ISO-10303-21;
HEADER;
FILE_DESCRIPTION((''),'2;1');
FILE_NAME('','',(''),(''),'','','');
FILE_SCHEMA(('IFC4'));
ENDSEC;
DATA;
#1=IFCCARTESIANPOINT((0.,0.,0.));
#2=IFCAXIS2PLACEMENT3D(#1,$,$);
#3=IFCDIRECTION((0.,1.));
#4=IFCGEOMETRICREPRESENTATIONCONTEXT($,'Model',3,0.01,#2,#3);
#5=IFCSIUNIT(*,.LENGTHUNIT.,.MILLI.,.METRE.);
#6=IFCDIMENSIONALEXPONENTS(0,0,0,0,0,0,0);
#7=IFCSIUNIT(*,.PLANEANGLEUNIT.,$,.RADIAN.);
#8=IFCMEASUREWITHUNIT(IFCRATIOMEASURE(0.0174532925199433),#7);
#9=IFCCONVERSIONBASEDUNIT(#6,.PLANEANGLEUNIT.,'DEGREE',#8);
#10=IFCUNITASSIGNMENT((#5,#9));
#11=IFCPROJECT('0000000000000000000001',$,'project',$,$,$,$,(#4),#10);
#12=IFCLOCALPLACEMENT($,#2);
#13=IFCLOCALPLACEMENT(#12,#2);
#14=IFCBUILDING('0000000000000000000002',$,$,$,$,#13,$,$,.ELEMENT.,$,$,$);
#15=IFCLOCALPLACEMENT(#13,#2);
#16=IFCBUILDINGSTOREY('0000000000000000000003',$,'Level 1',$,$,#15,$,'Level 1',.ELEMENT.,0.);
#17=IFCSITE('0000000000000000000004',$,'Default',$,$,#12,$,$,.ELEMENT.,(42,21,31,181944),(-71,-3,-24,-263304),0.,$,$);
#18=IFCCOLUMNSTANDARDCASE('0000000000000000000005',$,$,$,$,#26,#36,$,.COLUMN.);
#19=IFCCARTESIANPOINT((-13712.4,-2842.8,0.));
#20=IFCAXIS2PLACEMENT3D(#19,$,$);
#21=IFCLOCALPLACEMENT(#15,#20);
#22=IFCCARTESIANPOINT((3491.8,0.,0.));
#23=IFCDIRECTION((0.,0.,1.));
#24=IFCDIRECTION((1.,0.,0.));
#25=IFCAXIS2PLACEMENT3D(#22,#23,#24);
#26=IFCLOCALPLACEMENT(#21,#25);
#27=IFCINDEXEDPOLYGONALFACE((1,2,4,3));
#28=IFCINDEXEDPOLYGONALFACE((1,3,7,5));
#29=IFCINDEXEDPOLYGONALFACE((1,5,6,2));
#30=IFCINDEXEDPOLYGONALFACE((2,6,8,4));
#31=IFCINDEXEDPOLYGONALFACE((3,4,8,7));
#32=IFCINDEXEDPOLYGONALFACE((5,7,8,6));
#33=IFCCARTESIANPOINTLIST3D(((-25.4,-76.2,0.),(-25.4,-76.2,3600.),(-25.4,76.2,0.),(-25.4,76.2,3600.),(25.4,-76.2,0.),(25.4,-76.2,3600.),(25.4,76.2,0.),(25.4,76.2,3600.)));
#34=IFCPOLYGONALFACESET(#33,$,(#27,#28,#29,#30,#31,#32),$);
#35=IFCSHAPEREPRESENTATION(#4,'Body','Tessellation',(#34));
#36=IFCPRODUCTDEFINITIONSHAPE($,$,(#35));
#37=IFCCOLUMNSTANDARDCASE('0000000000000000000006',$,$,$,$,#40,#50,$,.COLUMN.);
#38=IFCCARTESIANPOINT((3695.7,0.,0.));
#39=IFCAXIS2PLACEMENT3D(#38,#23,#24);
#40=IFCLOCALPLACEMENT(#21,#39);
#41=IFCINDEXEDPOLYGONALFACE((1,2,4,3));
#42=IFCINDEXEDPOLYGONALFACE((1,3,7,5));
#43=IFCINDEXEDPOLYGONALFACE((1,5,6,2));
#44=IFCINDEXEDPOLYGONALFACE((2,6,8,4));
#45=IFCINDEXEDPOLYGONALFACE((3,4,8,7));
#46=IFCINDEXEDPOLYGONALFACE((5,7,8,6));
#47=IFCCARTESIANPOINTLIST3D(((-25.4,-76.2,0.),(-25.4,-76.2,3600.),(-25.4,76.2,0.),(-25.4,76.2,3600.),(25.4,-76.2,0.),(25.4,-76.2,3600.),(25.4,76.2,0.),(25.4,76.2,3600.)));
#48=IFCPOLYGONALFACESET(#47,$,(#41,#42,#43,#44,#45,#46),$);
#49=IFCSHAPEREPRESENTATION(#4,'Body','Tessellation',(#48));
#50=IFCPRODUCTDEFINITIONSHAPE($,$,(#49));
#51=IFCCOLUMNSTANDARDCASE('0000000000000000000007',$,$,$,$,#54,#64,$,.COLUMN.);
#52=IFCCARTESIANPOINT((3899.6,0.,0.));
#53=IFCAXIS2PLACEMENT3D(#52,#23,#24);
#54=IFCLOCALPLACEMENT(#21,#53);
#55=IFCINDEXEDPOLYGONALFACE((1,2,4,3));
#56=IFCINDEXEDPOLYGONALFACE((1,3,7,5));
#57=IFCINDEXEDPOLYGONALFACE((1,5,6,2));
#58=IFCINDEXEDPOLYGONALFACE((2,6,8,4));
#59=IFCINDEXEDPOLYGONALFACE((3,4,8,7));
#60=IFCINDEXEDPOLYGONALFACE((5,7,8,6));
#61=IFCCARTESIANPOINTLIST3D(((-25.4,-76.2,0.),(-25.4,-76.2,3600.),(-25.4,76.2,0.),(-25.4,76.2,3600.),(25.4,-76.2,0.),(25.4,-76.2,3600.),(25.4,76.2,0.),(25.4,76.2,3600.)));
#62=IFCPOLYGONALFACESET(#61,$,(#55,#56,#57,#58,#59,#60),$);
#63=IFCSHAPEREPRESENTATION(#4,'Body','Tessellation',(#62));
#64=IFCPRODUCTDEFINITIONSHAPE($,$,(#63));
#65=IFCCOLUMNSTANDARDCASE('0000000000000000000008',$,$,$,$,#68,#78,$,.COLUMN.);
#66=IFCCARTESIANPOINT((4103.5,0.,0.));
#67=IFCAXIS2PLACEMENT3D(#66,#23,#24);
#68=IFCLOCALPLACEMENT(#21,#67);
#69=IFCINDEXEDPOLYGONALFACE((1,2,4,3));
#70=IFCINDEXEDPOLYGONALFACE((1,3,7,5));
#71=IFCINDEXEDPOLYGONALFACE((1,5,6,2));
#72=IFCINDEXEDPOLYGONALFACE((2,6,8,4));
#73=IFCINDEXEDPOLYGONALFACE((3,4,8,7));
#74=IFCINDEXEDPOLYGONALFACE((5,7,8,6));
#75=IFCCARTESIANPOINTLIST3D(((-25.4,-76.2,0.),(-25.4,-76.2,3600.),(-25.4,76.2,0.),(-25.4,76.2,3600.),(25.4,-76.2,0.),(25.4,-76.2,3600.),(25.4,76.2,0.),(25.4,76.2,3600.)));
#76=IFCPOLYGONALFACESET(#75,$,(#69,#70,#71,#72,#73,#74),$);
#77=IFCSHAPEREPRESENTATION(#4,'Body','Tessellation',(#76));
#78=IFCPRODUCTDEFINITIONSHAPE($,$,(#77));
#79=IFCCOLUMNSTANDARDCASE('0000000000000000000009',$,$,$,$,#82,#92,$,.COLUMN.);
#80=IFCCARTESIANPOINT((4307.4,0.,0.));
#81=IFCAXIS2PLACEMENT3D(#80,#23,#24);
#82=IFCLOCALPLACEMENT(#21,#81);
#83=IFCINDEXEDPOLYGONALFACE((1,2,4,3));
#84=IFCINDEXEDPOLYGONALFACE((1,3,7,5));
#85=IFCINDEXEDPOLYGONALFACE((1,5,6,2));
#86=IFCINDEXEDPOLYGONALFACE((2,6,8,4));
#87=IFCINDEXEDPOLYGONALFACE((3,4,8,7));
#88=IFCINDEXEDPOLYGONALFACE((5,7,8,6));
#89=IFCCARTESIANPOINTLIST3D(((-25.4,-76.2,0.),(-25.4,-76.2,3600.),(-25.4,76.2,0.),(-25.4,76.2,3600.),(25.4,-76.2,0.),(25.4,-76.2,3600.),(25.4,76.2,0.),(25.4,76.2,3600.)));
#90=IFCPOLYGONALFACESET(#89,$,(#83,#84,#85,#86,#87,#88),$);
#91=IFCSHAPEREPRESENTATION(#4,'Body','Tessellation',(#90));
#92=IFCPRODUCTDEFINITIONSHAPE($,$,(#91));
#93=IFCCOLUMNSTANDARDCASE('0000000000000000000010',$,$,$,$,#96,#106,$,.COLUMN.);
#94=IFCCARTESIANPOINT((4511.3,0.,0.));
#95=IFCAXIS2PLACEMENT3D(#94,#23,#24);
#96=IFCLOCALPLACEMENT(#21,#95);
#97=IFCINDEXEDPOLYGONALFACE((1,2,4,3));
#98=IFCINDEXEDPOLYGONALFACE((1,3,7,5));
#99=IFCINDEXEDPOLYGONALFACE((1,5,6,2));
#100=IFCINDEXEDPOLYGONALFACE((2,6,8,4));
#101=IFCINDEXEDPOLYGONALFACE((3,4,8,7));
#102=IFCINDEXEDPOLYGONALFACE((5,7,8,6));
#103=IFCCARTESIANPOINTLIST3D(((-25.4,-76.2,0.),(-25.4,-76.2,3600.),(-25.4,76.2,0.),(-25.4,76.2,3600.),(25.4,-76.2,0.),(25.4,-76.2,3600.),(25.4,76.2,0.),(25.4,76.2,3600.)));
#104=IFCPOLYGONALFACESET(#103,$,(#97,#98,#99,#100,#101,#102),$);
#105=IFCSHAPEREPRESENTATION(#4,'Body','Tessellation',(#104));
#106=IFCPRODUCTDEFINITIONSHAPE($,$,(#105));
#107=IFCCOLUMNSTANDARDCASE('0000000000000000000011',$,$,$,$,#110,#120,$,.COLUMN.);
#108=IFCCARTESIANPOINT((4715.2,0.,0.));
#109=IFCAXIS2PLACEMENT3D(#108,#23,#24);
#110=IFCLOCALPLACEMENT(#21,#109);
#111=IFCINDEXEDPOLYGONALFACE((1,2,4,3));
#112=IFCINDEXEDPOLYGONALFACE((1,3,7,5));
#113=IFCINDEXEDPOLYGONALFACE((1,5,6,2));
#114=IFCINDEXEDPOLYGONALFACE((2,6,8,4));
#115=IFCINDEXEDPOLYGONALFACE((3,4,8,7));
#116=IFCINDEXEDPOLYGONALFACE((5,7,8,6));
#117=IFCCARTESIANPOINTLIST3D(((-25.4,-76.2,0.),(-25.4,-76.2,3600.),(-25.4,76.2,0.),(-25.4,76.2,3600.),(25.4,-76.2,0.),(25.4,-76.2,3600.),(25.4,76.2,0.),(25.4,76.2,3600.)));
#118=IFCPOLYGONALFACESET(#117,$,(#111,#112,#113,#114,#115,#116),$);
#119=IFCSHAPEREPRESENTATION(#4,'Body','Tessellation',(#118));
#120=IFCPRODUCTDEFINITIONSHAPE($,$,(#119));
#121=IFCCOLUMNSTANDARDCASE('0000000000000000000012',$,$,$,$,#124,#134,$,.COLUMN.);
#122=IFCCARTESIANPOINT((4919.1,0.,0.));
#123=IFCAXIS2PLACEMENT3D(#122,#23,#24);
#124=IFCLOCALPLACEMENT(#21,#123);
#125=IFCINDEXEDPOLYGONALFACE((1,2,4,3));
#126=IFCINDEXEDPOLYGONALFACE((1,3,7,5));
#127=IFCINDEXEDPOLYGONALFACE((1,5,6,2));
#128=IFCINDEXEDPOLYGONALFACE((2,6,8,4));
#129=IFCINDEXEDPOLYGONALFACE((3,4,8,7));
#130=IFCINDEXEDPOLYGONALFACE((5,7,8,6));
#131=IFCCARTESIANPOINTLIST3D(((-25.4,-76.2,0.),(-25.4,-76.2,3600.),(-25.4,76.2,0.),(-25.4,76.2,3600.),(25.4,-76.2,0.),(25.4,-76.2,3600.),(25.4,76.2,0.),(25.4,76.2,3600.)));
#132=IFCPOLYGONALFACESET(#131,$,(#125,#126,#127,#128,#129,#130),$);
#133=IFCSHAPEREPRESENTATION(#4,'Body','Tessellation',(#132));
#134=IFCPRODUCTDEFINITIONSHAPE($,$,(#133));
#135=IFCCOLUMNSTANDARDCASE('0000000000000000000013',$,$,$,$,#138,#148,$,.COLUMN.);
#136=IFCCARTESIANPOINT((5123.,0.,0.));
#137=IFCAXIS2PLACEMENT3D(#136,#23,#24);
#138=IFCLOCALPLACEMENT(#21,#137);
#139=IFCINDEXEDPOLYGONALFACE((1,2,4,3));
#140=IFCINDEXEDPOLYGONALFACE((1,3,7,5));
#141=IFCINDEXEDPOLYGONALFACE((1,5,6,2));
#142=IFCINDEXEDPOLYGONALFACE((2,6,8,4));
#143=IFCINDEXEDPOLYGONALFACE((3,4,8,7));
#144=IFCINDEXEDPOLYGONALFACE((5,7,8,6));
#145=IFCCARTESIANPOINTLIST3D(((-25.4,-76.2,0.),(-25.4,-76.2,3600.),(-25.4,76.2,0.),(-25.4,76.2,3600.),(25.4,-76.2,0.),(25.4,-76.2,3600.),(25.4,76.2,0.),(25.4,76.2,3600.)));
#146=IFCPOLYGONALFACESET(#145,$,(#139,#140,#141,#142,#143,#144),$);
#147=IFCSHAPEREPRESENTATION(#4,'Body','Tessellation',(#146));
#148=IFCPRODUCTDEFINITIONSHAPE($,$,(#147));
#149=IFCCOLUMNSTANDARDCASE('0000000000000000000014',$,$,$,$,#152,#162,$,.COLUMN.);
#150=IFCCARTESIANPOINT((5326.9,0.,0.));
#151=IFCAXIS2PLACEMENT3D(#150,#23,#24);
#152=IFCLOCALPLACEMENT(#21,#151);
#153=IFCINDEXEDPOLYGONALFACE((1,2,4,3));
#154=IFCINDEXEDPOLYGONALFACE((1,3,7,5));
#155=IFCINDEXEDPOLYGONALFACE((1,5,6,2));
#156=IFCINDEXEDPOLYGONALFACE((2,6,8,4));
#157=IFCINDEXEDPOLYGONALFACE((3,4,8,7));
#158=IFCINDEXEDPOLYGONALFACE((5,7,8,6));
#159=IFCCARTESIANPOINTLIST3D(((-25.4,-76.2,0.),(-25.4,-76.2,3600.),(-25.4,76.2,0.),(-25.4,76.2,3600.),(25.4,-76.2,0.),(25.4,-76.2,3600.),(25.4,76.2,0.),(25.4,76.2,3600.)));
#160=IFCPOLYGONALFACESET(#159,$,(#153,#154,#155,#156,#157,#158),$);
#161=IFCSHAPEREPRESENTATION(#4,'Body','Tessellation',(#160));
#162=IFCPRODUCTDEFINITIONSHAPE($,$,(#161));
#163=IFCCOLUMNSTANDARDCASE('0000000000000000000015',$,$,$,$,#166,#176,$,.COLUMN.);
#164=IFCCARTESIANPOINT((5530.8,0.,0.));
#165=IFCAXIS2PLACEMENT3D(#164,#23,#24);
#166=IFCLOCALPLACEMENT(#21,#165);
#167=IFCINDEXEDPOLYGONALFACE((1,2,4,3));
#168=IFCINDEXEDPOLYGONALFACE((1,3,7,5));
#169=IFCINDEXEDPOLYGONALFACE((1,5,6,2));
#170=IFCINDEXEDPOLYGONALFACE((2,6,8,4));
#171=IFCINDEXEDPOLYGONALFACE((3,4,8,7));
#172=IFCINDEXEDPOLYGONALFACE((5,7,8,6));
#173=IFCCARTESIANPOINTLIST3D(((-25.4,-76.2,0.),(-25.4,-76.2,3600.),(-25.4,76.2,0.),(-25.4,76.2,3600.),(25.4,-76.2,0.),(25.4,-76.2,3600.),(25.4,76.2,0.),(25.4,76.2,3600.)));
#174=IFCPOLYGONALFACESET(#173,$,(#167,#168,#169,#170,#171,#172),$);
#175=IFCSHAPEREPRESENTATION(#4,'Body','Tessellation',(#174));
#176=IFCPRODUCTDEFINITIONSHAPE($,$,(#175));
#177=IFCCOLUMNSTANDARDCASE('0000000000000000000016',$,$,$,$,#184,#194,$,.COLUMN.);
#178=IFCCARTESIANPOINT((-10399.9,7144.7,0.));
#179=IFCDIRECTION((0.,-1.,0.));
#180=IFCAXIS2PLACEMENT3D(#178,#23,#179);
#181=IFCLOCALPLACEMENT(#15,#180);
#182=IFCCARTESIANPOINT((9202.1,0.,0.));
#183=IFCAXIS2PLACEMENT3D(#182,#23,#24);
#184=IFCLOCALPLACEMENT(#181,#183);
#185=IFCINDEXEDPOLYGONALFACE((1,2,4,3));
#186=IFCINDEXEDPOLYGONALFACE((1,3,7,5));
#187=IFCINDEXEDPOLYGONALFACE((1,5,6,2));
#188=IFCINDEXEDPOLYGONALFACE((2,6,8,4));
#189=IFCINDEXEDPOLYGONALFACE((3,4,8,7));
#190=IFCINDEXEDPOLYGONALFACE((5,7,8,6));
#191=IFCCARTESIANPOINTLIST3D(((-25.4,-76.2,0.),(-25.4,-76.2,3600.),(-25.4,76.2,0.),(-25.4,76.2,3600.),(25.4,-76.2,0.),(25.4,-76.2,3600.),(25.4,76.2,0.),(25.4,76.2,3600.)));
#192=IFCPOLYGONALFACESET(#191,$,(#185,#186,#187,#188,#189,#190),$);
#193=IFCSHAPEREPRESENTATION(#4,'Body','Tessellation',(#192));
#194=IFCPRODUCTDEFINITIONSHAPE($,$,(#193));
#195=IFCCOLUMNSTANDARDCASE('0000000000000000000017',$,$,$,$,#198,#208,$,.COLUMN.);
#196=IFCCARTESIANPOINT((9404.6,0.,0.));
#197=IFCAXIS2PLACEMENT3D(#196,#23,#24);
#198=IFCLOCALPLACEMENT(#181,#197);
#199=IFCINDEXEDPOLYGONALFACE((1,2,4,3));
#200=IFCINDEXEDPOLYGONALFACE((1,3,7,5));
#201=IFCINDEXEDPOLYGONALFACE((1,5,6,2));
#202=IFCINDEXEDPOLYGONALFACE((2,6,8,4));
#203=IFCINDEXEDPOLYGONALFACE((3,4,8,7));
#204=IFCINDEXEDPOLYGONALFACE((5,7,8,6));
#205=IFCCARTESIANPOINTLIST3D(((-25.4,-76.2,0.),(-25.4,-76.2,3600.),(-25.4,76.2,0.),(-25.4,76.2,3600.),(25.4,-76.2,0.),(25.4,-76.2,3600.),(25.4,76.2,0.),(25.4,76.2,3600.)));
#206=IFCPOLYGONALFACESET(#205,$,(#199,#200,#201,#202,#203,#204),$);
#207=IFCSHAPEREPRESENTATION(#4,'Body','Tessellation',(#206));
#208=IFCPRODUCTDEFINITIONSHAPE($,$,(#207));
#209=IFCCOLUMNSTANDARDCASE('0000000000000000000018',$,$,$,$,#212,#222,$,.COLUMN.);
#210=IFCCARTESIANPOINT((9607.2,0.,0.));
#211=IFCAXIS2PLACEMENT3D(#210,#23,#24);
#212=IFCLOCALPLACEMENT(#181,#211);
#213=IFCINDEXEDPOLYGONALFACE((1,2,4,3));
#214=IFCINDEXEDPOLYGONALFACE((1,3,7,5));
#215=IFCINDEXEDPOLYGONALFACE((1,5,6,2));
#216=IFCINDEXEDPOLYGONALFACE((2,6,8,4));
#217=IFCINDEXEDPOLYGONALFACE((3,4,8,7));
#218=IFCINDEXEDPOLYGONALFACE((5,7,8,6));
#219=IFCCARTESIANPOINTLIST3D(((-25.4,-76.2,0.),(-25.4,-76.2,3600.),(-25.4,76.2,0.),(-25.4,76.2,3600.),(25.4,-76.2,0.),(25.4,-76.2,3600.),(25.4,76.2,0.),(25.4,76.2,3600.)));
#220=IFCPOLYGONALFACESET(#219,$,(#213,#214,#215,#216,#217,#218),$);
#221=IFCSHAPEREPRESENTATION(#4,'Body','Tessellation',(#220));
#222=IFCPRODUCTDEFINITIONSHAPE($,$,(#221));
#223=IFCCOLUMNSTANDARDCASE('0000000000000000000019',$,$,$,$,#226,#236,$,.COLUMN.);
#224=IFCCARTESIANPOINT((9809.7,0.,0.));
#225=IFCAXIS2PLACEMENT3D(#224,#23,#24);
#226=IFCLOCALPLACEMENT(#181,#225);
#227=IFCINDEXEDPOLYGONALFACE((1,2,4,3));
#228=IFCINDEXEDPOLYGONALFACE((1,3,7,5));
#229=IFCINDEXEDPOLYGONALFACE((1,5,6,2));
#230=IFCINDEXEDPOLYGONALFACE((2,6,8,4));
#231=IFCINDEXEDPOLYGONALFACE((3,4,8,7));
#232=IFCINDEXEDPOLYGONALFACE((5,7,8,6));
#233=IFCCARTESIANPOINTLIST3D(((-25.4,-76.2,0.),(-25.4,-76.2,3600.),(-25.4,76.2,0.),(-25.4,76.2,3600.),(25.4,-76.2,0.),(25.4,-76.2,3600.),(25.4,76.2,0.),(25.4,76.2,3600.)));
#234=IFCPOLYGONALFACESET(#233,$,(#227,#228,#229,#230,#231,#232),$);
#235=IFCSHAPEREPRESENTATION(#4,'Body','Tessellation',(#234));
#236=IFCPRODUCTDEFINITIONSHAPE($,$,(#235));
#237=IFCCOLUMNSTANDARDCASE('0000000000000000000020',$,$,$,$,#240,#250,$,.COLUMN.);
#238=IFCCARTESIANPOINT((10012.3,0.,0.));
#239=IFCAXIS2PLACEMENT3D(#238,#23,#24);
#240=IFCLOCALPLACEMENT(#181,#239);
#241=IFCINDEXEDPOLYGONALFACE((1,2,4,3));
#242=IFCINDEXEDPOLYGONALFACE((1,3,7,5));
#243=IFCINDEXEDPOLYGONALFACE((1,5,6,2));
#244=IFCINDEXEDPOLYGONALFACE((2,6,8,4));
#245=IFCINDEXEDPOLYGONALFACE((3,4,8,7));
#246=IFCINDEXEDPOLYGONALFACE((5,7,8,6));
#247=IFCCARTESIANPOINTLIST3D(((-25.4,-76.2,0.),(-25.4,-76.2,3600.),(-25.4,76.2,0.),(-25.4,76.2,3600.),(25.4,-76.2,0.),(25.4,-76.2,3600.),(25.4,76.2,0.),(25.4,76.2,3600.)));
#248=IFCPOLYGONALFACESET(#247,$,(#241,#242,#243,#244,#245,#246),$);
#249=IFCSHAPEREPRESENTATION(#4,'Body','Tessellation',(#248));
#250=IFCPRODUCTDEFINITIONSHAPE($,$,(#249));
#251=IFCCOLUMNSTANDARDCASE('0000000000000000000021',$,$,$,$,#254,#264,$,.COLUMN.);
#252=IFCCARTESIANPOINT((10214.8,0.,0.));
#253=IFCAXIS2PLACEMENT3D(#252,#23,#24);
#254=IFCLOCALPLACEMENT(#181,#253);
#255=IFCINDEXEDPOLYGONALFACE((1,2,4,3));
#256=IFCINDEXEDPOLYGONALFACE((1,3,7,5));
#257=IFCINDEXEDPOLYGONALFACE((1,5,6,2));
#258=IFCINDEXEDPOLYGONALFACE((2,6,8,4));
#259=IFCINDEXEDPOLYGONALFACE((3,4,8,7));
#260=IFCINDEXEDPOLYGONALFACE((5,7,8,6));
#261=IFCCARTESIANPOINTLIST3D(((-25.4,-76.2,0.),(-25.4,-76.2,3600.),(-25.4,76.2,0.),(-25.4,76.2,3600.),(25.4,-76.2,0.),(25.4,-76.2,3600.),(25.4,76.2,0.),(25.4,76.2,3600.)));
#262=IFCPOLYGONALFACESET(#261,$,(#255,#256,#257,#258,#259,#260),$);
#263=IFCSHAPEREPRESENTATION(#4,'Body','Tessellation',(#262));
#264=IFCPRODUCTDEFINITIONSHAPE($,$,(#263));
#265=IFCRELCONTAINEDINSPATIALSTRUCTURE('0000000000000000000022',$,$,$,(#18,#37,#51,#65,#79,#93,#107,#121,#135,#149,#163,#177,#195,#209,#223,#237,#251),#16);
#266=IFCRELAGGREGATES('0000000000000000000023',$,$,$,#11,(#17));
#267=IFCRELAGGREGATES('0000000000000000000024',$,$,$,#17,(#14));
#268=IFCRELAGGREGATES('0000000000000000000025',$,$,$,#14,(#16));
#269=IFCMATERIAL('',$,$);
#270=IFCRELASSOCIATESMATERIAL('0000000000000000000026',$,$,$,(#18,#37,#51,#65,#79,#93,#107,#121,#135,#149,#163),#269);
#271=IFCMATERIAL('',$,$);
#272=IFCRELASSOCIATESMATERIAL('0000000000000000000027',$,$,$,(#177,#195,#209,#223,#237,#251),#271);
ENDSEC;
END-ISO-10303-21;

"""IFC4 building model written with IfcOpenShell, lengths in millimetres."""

from ifc_helpers import new_model, entity, si_unit, converted_unit, direction, frame, origin, place, context, project, spatial, rectangle, extrude, material, element, save


model = new_model("IFC4")

# Units and contexts
model_context = context("Model", 3, precision=0.01, world=origin(), true_north=direction((0.0, 1.0)))
ifc_project = project(units=[si_unit("LENGTHUNIT", "METRE", prefix="MILLI"), converted_unit("PLANEANGLEUNIT", "DEGREE", entity("IfcRatioMeasure", 0.0174532925199433), si_unit("PLANEANGLEUNIT", "RADIAN"), dimensions=[0, 0, 0, 0, 0, 0, 0])], contexts=[model_context])

# Site, building, storey
site_placement = place(None, origin())
site = spatial("IfcSite", under=ifc_project, at=site_placement, Name="Default", CompositionType="ELEMENT", RefLatitude=(42, 21, 31, 181944), RefLongitude=(-71, -3, -24, -263304), RefElevation=0.0)
building_placement = place(site_placement, origin())
building = spatial("IfcBuilding", under=site, at=building_placement, CompositionType="ELEMENT")
storey_placement = place(building_placement, origin())
storey = spatial("IfcBuildingStorey", under=building, at=storey_placement, Name="Level 1", LongName="Level 1", CompositionType="ELEMENT", Elevation=0.0)

# Columns
ifc_material_1 = material(Name="")
placement_1 = place(storey_placement, frame((-13712.4, -2842.8, 0.0)))
for number, where, z_axis, x_axis in (
    (1, (3491.8, 0.0, 0.0), (0.0, 0.0, 1.0), (1.0, 0.0, 0.0)),
    (2, (3695.7, 0.0, 0.0), (0.0, 0.0, 1.0), (1.0, 0.0, 0.0)),
    (3, (3899.6, 0.0, 0.0), (0.0, 0.0, 1.0), (1.0, 0.0, 0.0)),
    (4, (4103.5, 0.0, 0.0), (0.0, 0.0, 1.0), (1.0, 0.0, 0.0)),
    (5, (4307.4, 0.0, 0.0), (0.0, 0.0, 1.0), (1.0, 0.0, 0.0)),
    (6, (4511.3, 0.0, 0.0), (0.0, 0.0, 1.0), (1.0, 0.0, 0.0)),
    (7, (4715.2, 0.0, 0.0), (0.0, 0.0, 1.0), (1.0, 0.0, 0.0)),
    (8, (4919.1, 0.0, 0.0), (0.0, 0.0, 1.0), (1.0, 0.0, 0.0)),
    (9, (5123.0, 0.0, 0.0), (0.0, 0.0, 1.0), (1.0, 0.0, 0.0)),
    (10, (5326.9, 0.0, 0.0), (0.0, 0.0, 1.0), (1.0, 0.0, 0.0)),
    (11, (5530.8, 0.0, 0.0), (0.0, 0.0, 1.0), (1.0, 0.0, 0.0)),
):
    element("IfcColumnStandardCase", number, at=place(placement_1, frame(where, z_axis=z_axis, x_axis=x_axis)), inside=storey, material=ifc_material_1, PredefinedType="COLUMN", context=model_context, shape_type="SweptSolid", body=[
        extrude(rectangle(XDim=50.8, YDim=152.4), origin(), (0.0, 0.0, 1.0), 3600.0),
    ])
ifc_material_2 = material(Name="")
placement_2 = place(storey_placement, frame((-10399.9, 7144.7, 0.0), z_axis=(0.0, 0.0, 1.0), x_axis=(0.0, -1.0, 0.0)))
for number, where, z_axis, x_axis in (
    (12, (9202.1, 0.0, 0.0), (0.0, 0.0, 1.0), (1.0, 0.0, 0.0)),
    (13, (9404.6, 0.0, 0.0), (0.0, 0.0, 1.0), (1.0, 0.0, 0.0)),
    (14, (9607.2, 0.0, 0.0), (0.0, 0.0, 1.0), (1.0, 0.0, 0.0)),
    (15, (9809.7, 0.0, 0.0), (0.0, 0.0, 1.0), (1.0, 0.0, 0.0)),
    (16, (10012.3, 0.0, 0.0), (0.0, 0.0, 1.0), (1.0, 0.0, 0.0)),
    (17, (10214.8, 0.0, 0.0), (0.0, 0.0, 1.0), (1.0, 0.0, 0.0)),
):
    element("IfcColumnStandardCase", number, at=place(placement_2, frame(where, z_axis=z_axis, x_axis=x_axis)), inside=storey, material=ifc_material_2, PredefinedType="COLUMN", context=model_context, shape_type="SweptSolid", body=[
        extrude(rectangle(XDim=50.8, YDim=152.4), origin(), (0.0, 0.0, 1.0), 3600.0),
    ])

save(model, "model.ifc")
